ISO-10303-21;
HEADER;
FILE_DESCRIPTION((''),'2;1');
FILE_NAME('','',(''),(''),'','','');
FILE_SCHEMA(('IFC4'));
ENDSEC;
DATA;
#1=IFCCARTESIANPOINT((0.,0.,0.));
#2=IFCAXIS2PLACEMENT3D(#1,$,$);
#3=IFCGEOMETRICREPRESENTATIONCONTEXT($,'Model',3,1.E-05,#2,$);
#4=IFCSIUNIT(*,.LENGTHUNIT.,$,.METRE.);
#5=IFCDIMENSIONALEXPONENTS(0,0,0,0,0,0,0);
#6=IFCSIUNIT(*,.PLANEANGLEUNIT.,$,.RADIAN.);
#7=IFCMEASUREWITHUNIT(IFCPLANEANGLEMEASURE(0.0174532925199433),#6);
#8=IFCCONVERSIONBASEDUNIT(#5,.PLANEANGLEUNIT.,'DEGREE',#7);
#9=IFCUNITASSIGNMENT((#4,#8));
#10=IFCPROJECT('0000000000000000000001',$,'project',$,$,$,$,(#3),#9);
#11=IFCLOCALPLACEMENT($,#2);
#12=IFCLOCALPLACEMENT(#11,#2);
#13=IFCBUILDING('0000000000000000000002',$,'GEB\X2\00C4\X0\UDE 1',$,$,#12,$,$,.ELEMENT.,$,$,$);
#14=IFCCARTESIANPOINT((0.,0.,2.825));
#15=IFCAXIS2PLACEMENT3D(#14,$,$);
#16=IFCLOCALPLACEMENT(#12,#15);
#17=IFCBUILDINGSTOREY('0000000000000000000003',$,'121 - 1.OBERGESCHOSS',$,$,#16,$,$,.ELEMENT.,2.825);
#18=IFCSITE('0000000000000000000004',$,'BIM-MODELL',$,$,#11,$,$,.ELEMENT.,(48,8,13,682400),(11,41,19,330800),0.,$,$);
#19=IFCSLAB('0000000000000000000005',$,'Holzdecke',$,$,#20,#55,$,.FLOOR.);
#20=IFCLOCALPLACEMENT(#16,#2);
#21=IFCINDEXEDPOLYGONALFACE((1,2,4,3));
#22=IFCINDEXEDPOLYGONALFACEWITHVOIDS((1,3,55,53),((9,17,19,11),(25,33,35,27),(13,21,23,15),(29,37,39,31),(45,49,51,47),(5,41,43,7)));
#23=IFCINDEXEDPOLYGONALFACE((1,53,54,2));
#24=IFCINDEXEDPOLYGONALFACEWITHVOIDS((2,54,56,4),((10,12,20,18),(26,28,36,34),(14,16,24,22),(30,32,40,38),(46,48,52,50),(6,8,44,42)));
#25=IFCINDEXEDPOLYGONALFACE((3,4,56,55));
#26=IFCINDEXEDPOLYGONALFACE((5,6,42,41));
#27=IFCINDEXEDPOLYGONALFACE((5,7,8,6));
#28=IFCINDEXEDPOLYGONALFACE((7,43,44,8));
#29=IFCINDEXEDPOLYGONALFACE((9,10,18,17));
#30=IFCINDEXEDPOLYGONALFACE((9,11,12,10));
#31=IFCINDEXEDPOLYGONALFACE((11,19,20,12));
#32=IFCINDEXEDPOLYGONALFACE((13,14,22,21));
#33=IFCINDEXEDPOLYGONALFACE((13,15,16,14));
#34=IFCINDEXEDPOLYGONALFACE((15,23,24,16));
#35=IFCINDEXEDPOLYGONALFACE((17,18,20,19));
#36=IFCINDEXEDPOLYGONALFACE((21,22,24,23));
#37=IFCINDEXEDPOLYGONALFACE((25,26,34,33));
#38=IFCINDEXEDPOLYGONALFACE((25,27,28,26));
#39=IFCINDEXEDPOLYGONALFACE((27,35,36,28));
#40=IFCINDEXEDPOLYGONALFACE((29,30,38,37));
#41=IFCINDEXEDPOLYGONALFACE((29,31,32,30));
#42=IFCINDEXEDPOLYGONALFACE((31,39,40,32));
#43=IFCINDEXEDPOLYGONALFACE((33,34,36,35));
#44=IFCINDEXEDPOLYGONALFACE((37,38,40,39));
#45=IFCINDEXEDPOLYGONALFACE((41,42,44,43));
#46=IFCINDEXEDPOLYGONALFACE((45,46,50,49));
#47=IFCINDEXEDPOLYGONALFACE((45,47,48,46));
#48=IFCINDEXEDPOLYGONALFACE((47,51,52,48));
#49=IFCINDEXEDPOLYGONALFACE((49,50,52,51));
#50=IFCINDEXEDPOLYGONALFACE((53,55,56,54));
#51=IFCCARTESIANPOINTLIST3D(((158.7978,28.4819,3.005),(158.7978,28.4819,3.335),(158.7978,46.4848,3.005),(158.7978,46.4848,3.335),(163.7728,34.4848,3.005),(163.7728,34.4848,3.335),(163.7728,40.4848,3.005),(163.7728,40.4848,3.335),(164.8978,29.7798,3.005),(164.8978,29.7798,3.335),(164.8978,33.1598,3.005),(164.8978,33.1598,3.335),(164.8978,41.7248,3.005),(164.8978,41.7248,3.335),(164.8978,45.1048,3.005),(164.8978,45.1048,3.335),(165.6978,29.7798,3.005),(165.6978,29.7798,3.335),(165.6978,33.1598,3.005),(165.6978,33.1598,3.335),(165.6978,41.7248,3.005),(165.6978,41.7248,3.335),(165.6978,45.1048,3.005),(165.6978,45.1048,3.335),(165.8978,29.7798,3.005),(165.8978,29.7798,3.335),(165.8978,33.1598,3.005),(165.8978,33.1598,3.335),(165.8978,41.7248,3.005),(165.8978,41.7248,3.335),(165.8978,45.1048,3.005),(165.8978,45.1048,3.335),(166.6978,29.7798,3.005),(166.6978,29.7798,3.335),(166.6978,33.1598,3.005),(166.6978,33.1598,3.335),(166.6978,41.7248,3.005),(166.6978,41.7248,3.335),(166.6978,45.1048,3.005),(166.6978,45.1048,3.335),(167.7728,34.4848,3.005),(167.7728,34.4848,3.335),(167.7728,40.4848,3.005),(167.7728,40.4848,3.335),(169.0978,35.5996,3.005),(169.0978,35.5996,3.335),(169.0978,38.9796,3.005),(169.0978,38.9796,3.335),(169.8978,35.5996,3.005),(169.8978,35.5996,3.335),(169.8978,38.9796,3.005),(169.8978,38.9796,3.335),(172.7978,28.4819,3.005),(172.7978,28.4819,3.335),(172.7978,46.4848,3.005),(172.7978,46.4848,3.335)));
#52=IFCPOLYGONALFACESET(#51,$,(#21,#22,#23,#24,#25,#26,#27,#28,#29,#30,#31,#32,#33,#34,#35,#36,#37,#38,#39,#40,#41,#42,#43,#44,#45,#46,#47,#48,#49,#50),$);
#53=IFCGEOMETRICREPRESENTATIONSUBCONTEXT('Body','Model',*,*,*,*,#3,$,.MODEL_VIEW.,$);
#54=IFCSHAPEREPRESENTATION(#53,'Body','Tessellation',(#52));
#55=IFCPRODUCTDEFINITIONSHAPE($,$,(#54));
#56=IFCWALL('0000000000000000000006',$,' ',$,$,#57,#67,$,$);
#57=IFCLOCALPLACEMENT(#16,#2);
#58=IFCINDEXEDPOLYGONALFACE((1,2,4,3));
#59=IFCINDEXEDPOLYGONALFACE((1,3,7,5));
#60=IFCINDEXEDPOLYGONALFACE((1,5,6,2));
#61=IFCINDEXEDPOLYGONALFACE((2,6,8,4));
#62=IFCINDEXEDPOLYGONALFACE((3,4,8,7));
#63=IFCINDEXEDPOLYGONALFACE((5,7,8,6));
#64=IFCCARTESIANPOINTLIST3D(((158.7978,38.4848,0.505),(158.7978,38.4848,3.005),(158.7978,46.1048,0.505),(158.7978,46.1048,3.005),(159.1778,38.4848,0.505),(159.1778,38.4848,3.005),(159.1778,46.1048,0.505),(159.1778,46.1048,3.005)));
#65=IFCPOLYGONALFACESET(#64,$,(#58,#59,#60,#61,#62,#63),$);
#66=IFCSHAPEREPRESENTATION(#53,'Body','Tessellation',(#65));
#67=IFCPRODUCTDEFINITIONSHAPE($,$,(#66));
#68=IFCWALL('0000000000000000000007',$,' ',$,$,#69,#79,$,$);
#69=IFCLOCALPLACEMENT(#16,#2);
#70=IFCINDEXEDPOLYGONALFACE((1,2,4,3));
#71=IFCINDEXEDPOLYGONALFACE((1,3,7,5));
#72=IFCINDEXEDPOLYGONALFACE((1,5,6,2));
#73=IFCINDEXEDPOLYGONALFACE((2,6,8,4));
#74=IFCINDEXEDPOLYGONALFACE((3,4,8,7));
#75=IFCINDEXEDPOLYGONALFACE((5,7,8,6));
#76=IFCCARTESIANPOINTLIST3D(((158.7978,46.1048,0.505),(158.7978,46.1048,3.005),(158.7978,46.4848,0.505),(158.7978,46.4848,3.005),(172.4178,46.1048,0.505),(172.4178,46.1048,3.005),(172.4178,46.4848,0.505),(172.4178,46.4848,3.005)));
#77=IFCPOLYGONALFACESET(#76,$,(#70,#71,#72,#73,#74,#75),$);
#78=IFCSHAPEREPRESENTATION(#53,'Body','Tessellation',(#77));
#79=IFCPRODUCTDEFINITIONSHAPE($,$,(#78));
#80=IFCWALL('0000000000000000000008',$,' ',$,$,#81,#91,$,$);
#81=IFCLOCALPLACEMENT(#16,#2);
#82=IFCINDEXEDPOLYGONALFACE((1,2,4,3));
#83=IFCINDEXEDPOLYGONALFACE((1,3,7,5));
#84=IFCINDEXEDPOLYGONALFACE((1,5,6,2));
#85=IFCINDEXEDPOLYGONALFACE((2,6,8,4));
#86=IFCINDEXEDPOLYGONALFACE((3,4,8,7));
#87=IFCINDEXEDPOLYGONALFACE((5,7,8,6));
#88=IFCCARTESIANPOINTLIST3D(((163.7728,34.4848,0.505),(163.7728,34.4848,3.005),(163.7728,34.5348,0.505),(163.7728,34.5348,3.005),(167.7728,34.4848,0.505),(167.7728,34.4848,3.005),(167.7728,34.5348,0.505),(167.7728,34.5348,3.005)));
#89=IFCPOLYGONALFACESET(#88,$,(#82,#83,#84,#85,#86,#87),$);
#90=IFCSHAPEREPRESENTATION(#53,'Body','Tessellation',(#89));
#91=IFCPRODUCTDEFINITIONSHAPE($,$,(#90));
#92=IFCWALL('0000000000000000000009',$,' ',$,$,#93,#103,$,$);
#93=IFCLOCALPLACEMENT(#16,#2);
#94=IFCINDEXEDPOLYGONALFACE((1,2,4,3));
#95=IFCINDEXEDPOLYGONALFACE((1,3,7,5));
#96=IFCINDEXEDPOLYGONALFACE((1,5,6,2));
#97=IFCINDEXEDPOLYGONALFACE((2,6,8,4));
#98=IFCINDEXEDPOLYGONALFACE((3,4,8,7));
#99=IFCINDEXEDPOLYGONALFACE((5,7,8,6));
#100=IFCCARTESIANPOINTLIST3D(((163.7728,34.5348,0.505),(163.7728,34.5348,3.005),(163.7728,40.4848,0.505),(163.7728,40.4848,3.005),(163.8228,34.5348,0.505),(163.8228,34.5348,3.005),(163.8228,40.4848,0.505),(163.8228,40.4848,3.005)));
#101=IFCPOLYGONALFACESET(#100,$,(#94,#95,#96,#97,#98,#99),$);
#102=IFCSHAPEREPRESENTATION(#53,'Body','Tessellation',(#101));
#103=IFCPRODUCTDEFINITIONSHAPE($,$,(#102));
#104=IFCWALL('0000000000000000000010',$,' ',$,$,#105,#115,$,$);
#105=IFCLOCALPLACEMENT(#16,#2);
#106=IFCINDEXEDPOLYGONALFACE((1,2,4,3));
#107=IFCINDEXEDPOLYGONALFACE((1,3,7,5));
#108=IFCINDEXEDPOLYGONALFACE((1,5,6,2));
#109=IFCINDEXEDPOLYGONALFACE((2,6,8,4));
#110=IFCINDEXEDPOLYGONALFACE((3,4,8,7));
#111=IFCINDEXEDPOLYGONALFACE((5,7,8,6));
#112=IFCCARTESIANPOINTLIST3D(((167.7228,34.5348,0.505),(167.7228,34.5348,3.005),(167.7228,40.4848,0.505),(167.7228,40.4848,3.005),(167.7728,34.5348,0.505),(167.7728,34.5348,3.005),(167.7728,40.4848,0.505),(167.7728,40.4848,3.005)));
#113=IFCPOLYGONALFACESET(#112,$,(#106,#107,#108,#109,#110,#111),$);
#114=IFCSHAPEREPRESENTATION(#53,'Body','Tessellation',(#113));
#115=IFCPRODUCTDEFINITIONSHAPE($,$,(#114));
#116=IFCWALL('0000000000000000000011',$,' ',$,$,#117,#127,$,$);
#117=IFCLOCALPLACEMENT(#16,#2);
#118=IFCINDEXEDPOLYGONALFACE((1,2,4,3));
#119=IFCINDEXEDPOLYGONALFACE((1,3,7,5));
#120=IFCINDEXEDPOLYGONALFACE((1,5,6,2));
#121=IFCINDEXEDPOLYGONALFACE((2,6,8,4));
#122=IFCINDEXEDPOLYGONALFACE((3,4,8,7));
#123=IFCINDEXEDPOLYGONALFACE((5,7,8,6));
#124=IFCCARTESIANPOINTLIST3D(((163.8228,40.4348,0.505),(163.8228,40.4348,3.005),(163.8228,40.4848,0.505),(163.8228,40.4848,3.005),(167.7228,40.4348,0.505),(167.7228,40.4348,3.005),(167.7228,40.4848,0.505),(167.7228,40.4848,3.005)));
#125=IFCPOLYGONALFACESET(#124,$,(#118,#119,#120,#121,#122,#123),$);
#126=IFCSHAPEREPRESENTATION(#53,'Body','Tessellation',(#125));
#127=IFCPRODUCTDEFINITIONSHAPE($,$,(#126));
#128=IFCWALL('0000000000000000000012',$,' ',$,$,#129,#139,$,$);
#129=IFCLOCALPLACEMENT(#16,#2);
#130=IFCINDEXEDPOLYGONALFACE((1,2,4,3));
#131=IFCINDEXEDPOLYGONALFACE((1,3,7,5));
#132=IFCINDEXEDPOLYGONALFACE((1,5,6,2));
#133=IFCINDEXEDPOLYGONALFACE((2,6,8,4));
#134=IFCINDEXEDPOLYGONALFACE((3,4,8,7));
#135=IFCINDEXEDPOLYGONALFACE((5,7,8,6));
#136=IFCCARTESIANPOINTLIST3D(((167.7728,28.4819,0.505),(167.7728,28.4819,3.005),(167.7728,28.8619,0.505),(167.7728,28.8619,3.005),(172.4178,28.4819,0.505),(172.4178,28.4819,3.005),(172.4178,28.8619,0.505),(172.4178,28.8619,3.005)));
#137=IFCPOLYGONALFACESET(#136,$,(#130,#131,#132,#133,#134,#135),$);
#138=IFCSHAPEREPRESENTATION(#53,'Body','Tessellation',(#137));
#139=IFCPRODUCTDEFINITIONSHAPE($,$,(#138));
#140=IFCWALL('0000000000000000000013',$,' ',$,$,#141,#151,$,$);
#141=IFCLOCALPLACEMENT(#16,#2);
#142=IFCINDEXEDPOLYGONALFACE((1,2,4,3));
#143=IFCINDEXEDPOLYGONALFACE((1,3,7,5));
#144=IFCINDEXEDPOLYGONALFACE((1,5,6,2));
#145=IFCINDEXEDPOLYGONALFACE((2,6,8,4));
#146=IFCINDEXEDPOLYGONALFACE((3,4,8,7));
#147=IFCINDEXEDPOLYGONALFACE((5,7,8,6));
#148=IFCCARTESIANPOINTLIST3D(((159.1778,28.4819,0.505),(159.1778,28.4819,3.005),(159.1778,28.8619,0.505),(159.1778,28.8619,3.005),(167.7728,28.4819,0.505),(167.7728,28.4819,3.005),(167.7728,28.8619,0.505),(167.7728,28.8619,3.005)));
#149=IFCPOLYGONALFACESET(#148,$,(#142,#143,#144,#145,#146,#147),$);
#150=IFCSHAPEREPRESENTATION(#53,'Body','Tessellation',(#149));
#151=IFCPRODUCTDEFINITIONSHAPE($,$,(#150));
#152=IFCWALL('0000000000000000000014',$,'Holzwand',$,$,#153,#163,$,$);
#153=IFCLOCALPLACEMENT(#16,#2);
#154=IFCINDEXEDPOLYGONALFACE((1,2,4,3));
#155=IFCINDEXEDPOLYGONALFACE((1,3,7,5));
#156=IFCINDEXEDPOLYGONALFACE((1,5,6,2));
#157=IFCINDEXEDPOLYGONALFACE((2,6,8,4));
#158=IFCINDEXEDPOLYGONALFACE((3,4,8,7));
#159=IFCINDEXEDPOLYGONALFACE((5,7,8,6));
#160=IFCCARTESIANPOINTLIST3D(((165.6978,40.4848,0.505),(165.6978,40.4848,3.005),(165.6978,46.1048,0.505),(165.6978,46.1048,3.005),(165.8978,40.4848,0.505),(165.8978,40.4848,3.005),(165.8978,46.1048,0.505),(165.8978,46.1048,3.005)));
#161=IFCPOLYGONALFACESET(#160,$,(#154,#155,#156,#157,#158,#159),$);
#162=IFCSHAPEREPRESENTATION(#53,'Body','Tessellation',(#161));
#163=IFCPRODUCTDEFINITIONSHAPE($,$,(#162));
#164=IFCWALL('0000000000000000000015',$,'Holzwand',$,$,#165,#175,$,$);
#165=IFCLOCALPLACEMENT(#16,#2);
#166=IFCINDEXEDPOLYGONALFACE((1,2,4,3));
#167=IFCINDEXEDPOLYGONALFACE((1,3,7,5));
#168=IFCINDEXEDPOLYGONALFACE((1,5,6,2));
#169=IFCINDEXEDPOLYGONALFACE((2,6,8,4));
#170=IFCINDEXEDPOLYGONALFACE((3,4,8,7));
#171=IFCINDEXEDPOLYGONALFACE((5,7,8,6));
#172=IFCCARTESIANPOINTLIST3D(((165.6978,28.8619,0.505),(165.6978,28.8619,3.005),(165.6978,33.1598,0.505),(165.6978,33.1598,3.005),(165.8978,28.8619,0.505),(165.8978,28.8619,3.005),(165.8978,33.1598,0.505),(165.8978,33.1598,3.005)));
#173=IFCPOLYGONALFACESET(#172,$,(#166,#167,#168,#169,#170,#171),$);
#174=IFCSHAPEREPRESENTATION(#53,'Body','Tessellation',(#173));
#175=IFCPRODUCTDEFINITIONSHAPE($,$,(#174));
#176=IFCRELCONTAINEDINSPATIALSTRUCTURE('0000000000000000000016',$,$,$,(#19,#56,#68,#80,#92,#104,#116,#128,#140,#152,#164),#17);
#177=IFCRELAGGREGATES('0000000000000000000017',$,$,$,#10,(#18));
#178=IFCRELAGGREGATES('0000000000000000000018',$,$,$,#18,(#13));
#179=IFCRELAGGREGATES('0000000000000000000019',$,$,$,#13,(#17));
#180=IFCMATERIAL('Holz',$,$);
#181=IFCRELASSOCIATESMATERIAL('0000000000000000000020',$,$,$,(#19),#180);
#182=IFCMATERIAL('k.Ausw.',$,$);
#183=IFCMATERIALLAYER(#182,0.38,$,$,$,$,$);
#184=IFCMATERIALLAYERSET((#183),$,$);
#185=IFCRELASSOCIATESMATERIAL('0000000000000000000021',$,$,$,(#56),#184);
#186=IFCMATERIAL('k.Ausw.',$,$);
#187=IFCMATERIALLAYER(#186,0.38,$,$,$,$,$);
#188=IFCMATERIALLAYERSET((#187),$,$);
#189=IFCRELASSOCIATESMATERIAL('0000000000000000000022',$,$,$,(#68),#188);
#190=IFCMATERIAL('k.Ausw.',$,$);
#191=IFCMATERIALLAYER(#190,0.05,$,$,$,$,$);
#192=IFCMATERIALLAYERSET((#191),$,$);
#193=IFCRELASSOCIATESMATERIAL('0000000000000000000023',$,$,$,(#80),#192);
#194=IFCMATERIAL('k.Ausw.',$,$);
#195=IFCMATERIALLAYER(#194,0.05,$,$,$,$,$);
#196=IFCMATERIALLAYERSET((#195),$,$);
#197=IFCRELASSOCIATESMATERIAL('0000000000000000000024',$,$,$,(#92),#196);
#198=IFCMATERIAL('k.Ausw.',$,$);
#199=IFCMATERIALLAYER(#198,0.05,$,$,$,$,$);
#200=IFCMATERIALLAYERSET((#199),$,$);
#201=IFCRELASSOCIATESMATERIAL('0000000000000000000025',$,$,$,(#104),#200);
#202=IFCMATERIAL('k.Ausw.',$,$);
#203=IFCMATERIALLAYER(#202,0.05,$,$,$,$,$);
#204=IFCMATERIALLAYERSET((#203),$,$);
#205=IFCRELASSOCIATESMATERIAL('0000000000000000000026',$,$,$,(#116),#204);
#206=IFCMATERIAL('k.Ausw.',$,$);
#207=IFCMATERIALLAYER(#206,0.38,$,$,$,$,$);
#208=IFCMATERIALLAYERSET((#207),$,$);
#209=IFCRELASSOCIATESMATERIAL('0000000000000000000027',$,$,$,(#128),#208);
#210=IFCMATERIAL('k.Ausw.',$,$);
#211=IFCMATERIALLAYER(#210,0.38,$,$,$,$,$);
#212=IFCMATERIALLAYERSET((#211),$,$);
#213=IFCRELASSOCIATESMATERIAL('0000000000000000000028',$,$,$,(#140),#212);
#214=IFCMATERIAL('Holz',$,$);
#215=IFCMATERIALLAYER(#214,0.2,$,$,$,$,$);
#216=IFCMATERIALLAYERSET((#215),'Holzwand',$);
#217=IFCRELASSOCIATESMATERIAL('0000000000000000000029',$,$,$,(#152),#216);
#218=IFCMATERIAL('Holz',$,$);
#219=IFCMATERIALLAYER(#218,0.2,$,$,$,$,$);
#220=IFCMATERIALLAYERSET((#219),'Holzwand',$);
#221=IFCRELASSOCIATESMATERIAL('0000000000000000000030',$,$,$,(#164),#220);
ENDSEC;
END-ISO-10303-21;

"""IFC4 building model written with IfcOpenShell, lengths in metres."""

from ifc_helpers import new_model, entity, si_unit, converted_unit, frame, frame_2d, origin, origin_with_axes, place, context, subcontext, project, spatial, polyline, rectangle, outline, extrude, material, layer, layer_set, layer_usage, element, save


model = new_model("IFC4")

# Units and contexts
model_context = context("Model", 3, precision=1e-05, world=origin())
body_context = subcontext(model_context, "Body", "Model", "MODEL_VIEW")
ifc_project = project(units=[si_unit("LENGTHUNIT", "METRE"), converted_unit("PLANEANGLEUNIT", "DEGREE", entity("IfcPlaneAngleMeasure", 0.0174532925199433), si_unit("PLANEANGLEUNIT", "RADIAN"), dimensions=[0, 0, 0, 0, 0, 0, 0])], contexts=[model_context])

# Site, building, storey
site_placement = place(None, origin())
site = spatial("IfcSite", under=ifc_project, at=site_placement, Name="BIM-MODELL", CompositionType="ELEMENT", RefLatitude=(48, 8, 13, 682400), RefLongitude=(11, 41, 19, 330800), RefElevation=0.0)
building_placement = place(site_placement, origin())
building = spatial("IfcBuilding", under=site, at=building_placement, Name="GEBÄUDE 1", CompositionType="ELEMENT")
storey_placement = place(building_placement, frame((0.0, 0.0, 2.825)))
storey = spatial("IfcBuildingStorey", under=building, at=storey_placement, Name="121 - 1.OBERGESCHOSS", CompositionType="ELEMENT", Elevation=2.825)

# Slab
ifc_material_1 = material(Name="Holz")
slab_placement = place(storey_placement, frame((158.7978, 28.4819, 3.005)))
element("IfcSlab", 1, at=slab_placement, inside=storey, material=ifc_material_1, Name="Holzdecke", PredefinedType="FLOOR", context=body_context, shape_type="SweptSolid", body=[
    extrude(outline(polyline([(0.0, 0.0), (14.0, 0.0), (14.0, 18.0029), (0.0, 18.0029), (0.0, 0.0)]), holes=[polyline([(8.975, 12.0029), (8.975, 6.0029), (4.975, 6.0029), (4.975, 12.0029), (8.975, 12.0029)]), polyline([(10.3, 10.4977), (11.1, 10.4977), (11.1, 7.1177), (10.3, 7.1177), (10.3, 10.4977)]), polyline([(7.9, 4.6779), (7.9, 1.2979), (7.1, 1.2979), (7.1, 4.6779), (7.9, 4.6779)]), polyline([(6.1, 4.6779), (6.9, 4.6779), (6.9, 1.2979), (6.1, 1.2979), (6.1, 4.6779)]), polyline([(7.1, 13.2429), (7.1, 16.6229), (7.9, 16.6229), (7.9, 13.2429), (7.1, 13.2429)]), polyline([(6.9, 13.2429), (6.1, 13.2429), (6.1, 16.6229), (6.9, 16.6229), (6.9, 13.2429)])]), origin_with_axes(), (0.0, 0.0, 1.0), 0.33),
])

# Walls
ifc_material_2 = material(Name="k.Ausw.")
ifc_layer_1 = layer(ifc_material_2, 0.38)
ifc_layer_set_1 = layer_set([ifc_layer_1])
ifc_layer_usage_1 = layer_usage(ifc_layer_set_1, "AXIS2", "POSITIVE", 0.0)
wall_1_placement = place(storey_placement, frame((158.7978, 46.1048, 0.505), z_axis=(0.0, 0.0, 1.0), x_axis=(0.0, -1.0, 0.0)))
element("IfcWall", 2, at=wall_1_placement, inside=storey, material=ifc_layer_usage_1, Name=" ", context=body_context, shape_type="SweptSolid", body=[
    extrude(rectangle(XDim=7.62, YDim=0.38, at=frame_2d((3.81, 0.19), x_axis=(1.0, 0.0))), origin_with_axes(), (0.0, 0.0, 1.0), 2.5),
])
ifc_material_3 = material(Name="k.Ausw.")
ifc_layer_2 = layer(ifc_material_3, 0.38)
ifc_layer_set_2 = layer_set([ifc_layer_2])
ifc_layer_usage_2 = layer_usage(ifc_layer_set_2, "AXIS2", "POSITIVE", 0.0)
wall_2_placement = place(storey_placement, frame((172.4178, 46.4848, 0.505), z_axis=(0.0, 0.0, 1.0), x_axis=(-1.0, 0.0, 0.0)))
element("IfcWall", 3, at=wall_2_placement, inside=storey, material=ifc_layer_usage_2, Name=" ", context=body_context, shape_type="SweptSolid", body=[
    extrude(rectangle(XDim=13.62, YDim=0.38, at=frame_2d((6.81, 0.19), x_axis=(1.0, 0.0))), origin_with_axes(), (0.0, 0.0, 1.0), 2.5),
])
ifc_material_4 = material(Name="k.Ausw.")
ifc_layer_3 = layer(ifc_material_4, 0.05)
ifc_layer_set_3 = layer_set([ifc_layer_3])
ifc_layer_usage_3 = layer_usage(ifc_layer_set_3, "AXIS2", "POSITIVE", 0.0)
wall_3_placement = place(storey_placement, frame((163.7728, 34.4848, 0.505), z_axis=(0.0, 0.0, 1.0), x_axis=(1.0, 0.0, 0.0)))
element("IfcWall", 4, at=wall_3_placement, inside=storey, material=ifc_layer_usage_3, Name=" ", context=body_context, shape_type="SweptSolid", body=[
    extrude(rectangle(XDim=4.0, YDim=0.05, at=frame_2d((2.0, 0.025), x_axis=(1.0, 0.0))), origin_with_axes(), (0.0, 0.0, 1.0), 2.5),
])
ifc_material_5 = material(Name="k.Ausw.")
ifc_layer_4 = layer(ifc_material_5, 0.05)
ifc_layer_set_4 = layer_set([ifc_layer_4])
ifc_layer_usage_4 = layer_usage(ifc_layer_set_4, "AXIS2", "POSITIVE", 0.0)
wall_4_placement = place(storey_placement, frame((163.7728, 40.4848, 0.505), z_axis=(0.0, 0.0, 1.0), x_axis=(0.0, -1.0, 0.0)))
element("IfcWall", 5, at=wall_4_placement, inside=storey, material=ifc_layer_usage_4, Name=" ", context=body_context, shape_type="SweptSolid", body=[
    extrude(rectangle(XDim=5.95, YDim=0.05, at=frame_2d((2.975, 0.025), x_axis=(1.0, 0.0))), origin_with_axes(), (0.0, 0.0, 1.0), 2.5),
])
ifc_material_6 = material(Name="k.Ausw.")
ifc_layer_5 = layer(ifc_material_6, 0.05)
ifc_layer_set_5 = layer_set([ifc_layer_5])
ifc_layer_usage_5 = layer_usage(ifc_layer_set_5, "AXIS2", "POSITIVE", 0.0)
wall_5_placement = place(storey_placement, frame((167.7728, 34.5348, 0.505), z_axis=(0.0, 0.0, 1.0), x_axis=(0.0, 1.0, 0.0)))
element("IfcWall", 6, at=wall_5_placement, inside=storey, material=ifc_layer_usage_5, Name=" ", context=body_context, shape_type="SweptSolid", body=[
    extrude(rectangle(XDim=5.95, YDim=0.05, at=frame_2d((2.975, 0.025), x_axis=(1.0, 0.0))), origin_with_axes(), (0.0, 0.0, 1.0), 2.5),
])
ifc_material_7 = material(Name="k.Ausw.")
ifc_layer_6 = layer(ifc_material_7, 0.05)
ifc_layer_set_6 = layer_set([ifc_layer_6])
ifc_layer_usage_6 = layer_usage(ifc_layer_set_6, "AXIS2", "POSITIVE", 0.0)
wall_6_placement = place(storey_placement, frame((167.7228, 40.4848, 0.505), z_axis=(0.0, 0.0, 1.0), x_axis=(-1.0, 0.0, 0.0)))
element("IfcWall", 7, at=wall_6_placement, inside=storey, material=ifc_layer_usage_6, Name=" ", context=body_context, shape_type="SweptSolid", body=[
    extrude(rectangle(XDim=3.9, YDim=0.05, at=frame_2d((1.95, 0.025), x_axis=(1.0, 0.0))), origin_with_axes(), (0.0, 0.0, 1.0), 2.5),
])
ifc_material_8 = material(Name="k.Ausw.")
ifc_layer_7 = layer(ifc_material_8, 0.38)
ifc_layer_set_7 = layer_set([ifc_layer_7])
ifc_layer_usage_7 = layer_usage(ifc_layer_set_7, "AXIS2", "POSITIVE", 0.0)
wall_7_placement = place(storey_placement, frame((167.7728, 28.4819, 0.505), z_axis=(0.0, 0.0, 1.0), x_axis=(1.0, 0.0, 0.0)))
element("IfcWall", 8, at=wall_7_placement, inside=storey, material=ifc_layer_usage_7, Name=" ", context=body_context, shape_type="SweptSolid", body=[
    extrude(rectangle(XDim=4.645, YDim=0.38, at=frame_2d((2.3225, 0.19), x_axis=(1.0, 0.0))), origin_with_axes(), (0.0, 0.0, 1.0), 2.5),
])
ifc_material_9 = material(Name="k.Ausw.")
ifc_layer_8 = layer(ifc_material_9, 0.38)
ifc_layer_set_8 = layer_set([ifc_layer_8])
ifc_layer_usage_8 = layer_usage(ifc_layer_set_8, "AXIS2", "POSITIVE", 0.0)
wall_8_placement = place(storey_placement, frame((159.1778, 28.4819, 0.505), z_axis=(0.0, 0.0, 1.0), x_axis=(1.0, 0.0, 0.0)))
element("IfcWall", 9, at=wall_8_placement, inside=storey, material=ifc_layer_usage_8, Name=" ", context=body_context, shape_type="SweptSolid", body=[
    extrude(rectangle(XDim=8.595, YDim=0.38, at=frame_2d((4.2975, 0.19), x_axis=(1.0, 0.0))), origin_with_axes(), (0.0, 0.0, 1.0), 2.5),
])
ifc_material_10 = material(Name="Holz")
ifc_layer_9 = layer(ifc_material_10, 0.2)
ifc_layer_set_9 = layer_set([ifc_layer_9], Name="Holzwand")
ifc_layer_usage_9 = layer_usage(ifc_layer_set_9, "AXIS2", "POSITIVE", 0.0)
wall_9_placement = place(storey_placement, frame((165.6978, 46.1048, 0.505), z_axis=(0.0, 0.0, 1.0), x_axis=(0.0, -1.0, 0.0)))
element("IfcWall", 10, at=wall_9_placement, inside=storey, material=ifc_layer_usage_9, Name="Holzwand", context=body_context, shape_type="SweptSolid", body=[
    extrude(rectangle(XDim=5.62, YDim=0.2, at=frame_2d((2.81, 0.1), x_axis=(1.0, 0.0))), origin_with_axes(), (0.0, 0.0, 1.0), 2.5),
])
ifc_material_11 = material(Name="Holz")
ifc_layer_10 = layer(ifc_material_11, 0.2)
ifc_layer_set_10 = layer_set([ifc_layer_10], Name="Holzwand")
ifc_layer_usage_10 = layer_usage(ifc_layer_set_10, "AXIS2", "POSITIVE", 0.0)
wall_10_placement = place(storey_placement, frame((165.6978, 33.1598, 0.505), z_axis=(0.0, 0.0, 1.0), x_axis=(0.0, -1.0, 0.0)))
element("IfcWall", 11, at=wall_10_placement, inside=storey, material=ifc_layer_usage_10, Name="Holzwand", context=body_context, shape_type="SweptSolid", body=[
    extrude(rectangle(XDim=4.2979, YDim=0.2, at=frame_2d((2.1489, 0.1), x_axis=(1.0, 0.0))), origin_with_axes(), (0.0, 0.0, 1.0), 2.5),
])

save(model, "model.ifc")
